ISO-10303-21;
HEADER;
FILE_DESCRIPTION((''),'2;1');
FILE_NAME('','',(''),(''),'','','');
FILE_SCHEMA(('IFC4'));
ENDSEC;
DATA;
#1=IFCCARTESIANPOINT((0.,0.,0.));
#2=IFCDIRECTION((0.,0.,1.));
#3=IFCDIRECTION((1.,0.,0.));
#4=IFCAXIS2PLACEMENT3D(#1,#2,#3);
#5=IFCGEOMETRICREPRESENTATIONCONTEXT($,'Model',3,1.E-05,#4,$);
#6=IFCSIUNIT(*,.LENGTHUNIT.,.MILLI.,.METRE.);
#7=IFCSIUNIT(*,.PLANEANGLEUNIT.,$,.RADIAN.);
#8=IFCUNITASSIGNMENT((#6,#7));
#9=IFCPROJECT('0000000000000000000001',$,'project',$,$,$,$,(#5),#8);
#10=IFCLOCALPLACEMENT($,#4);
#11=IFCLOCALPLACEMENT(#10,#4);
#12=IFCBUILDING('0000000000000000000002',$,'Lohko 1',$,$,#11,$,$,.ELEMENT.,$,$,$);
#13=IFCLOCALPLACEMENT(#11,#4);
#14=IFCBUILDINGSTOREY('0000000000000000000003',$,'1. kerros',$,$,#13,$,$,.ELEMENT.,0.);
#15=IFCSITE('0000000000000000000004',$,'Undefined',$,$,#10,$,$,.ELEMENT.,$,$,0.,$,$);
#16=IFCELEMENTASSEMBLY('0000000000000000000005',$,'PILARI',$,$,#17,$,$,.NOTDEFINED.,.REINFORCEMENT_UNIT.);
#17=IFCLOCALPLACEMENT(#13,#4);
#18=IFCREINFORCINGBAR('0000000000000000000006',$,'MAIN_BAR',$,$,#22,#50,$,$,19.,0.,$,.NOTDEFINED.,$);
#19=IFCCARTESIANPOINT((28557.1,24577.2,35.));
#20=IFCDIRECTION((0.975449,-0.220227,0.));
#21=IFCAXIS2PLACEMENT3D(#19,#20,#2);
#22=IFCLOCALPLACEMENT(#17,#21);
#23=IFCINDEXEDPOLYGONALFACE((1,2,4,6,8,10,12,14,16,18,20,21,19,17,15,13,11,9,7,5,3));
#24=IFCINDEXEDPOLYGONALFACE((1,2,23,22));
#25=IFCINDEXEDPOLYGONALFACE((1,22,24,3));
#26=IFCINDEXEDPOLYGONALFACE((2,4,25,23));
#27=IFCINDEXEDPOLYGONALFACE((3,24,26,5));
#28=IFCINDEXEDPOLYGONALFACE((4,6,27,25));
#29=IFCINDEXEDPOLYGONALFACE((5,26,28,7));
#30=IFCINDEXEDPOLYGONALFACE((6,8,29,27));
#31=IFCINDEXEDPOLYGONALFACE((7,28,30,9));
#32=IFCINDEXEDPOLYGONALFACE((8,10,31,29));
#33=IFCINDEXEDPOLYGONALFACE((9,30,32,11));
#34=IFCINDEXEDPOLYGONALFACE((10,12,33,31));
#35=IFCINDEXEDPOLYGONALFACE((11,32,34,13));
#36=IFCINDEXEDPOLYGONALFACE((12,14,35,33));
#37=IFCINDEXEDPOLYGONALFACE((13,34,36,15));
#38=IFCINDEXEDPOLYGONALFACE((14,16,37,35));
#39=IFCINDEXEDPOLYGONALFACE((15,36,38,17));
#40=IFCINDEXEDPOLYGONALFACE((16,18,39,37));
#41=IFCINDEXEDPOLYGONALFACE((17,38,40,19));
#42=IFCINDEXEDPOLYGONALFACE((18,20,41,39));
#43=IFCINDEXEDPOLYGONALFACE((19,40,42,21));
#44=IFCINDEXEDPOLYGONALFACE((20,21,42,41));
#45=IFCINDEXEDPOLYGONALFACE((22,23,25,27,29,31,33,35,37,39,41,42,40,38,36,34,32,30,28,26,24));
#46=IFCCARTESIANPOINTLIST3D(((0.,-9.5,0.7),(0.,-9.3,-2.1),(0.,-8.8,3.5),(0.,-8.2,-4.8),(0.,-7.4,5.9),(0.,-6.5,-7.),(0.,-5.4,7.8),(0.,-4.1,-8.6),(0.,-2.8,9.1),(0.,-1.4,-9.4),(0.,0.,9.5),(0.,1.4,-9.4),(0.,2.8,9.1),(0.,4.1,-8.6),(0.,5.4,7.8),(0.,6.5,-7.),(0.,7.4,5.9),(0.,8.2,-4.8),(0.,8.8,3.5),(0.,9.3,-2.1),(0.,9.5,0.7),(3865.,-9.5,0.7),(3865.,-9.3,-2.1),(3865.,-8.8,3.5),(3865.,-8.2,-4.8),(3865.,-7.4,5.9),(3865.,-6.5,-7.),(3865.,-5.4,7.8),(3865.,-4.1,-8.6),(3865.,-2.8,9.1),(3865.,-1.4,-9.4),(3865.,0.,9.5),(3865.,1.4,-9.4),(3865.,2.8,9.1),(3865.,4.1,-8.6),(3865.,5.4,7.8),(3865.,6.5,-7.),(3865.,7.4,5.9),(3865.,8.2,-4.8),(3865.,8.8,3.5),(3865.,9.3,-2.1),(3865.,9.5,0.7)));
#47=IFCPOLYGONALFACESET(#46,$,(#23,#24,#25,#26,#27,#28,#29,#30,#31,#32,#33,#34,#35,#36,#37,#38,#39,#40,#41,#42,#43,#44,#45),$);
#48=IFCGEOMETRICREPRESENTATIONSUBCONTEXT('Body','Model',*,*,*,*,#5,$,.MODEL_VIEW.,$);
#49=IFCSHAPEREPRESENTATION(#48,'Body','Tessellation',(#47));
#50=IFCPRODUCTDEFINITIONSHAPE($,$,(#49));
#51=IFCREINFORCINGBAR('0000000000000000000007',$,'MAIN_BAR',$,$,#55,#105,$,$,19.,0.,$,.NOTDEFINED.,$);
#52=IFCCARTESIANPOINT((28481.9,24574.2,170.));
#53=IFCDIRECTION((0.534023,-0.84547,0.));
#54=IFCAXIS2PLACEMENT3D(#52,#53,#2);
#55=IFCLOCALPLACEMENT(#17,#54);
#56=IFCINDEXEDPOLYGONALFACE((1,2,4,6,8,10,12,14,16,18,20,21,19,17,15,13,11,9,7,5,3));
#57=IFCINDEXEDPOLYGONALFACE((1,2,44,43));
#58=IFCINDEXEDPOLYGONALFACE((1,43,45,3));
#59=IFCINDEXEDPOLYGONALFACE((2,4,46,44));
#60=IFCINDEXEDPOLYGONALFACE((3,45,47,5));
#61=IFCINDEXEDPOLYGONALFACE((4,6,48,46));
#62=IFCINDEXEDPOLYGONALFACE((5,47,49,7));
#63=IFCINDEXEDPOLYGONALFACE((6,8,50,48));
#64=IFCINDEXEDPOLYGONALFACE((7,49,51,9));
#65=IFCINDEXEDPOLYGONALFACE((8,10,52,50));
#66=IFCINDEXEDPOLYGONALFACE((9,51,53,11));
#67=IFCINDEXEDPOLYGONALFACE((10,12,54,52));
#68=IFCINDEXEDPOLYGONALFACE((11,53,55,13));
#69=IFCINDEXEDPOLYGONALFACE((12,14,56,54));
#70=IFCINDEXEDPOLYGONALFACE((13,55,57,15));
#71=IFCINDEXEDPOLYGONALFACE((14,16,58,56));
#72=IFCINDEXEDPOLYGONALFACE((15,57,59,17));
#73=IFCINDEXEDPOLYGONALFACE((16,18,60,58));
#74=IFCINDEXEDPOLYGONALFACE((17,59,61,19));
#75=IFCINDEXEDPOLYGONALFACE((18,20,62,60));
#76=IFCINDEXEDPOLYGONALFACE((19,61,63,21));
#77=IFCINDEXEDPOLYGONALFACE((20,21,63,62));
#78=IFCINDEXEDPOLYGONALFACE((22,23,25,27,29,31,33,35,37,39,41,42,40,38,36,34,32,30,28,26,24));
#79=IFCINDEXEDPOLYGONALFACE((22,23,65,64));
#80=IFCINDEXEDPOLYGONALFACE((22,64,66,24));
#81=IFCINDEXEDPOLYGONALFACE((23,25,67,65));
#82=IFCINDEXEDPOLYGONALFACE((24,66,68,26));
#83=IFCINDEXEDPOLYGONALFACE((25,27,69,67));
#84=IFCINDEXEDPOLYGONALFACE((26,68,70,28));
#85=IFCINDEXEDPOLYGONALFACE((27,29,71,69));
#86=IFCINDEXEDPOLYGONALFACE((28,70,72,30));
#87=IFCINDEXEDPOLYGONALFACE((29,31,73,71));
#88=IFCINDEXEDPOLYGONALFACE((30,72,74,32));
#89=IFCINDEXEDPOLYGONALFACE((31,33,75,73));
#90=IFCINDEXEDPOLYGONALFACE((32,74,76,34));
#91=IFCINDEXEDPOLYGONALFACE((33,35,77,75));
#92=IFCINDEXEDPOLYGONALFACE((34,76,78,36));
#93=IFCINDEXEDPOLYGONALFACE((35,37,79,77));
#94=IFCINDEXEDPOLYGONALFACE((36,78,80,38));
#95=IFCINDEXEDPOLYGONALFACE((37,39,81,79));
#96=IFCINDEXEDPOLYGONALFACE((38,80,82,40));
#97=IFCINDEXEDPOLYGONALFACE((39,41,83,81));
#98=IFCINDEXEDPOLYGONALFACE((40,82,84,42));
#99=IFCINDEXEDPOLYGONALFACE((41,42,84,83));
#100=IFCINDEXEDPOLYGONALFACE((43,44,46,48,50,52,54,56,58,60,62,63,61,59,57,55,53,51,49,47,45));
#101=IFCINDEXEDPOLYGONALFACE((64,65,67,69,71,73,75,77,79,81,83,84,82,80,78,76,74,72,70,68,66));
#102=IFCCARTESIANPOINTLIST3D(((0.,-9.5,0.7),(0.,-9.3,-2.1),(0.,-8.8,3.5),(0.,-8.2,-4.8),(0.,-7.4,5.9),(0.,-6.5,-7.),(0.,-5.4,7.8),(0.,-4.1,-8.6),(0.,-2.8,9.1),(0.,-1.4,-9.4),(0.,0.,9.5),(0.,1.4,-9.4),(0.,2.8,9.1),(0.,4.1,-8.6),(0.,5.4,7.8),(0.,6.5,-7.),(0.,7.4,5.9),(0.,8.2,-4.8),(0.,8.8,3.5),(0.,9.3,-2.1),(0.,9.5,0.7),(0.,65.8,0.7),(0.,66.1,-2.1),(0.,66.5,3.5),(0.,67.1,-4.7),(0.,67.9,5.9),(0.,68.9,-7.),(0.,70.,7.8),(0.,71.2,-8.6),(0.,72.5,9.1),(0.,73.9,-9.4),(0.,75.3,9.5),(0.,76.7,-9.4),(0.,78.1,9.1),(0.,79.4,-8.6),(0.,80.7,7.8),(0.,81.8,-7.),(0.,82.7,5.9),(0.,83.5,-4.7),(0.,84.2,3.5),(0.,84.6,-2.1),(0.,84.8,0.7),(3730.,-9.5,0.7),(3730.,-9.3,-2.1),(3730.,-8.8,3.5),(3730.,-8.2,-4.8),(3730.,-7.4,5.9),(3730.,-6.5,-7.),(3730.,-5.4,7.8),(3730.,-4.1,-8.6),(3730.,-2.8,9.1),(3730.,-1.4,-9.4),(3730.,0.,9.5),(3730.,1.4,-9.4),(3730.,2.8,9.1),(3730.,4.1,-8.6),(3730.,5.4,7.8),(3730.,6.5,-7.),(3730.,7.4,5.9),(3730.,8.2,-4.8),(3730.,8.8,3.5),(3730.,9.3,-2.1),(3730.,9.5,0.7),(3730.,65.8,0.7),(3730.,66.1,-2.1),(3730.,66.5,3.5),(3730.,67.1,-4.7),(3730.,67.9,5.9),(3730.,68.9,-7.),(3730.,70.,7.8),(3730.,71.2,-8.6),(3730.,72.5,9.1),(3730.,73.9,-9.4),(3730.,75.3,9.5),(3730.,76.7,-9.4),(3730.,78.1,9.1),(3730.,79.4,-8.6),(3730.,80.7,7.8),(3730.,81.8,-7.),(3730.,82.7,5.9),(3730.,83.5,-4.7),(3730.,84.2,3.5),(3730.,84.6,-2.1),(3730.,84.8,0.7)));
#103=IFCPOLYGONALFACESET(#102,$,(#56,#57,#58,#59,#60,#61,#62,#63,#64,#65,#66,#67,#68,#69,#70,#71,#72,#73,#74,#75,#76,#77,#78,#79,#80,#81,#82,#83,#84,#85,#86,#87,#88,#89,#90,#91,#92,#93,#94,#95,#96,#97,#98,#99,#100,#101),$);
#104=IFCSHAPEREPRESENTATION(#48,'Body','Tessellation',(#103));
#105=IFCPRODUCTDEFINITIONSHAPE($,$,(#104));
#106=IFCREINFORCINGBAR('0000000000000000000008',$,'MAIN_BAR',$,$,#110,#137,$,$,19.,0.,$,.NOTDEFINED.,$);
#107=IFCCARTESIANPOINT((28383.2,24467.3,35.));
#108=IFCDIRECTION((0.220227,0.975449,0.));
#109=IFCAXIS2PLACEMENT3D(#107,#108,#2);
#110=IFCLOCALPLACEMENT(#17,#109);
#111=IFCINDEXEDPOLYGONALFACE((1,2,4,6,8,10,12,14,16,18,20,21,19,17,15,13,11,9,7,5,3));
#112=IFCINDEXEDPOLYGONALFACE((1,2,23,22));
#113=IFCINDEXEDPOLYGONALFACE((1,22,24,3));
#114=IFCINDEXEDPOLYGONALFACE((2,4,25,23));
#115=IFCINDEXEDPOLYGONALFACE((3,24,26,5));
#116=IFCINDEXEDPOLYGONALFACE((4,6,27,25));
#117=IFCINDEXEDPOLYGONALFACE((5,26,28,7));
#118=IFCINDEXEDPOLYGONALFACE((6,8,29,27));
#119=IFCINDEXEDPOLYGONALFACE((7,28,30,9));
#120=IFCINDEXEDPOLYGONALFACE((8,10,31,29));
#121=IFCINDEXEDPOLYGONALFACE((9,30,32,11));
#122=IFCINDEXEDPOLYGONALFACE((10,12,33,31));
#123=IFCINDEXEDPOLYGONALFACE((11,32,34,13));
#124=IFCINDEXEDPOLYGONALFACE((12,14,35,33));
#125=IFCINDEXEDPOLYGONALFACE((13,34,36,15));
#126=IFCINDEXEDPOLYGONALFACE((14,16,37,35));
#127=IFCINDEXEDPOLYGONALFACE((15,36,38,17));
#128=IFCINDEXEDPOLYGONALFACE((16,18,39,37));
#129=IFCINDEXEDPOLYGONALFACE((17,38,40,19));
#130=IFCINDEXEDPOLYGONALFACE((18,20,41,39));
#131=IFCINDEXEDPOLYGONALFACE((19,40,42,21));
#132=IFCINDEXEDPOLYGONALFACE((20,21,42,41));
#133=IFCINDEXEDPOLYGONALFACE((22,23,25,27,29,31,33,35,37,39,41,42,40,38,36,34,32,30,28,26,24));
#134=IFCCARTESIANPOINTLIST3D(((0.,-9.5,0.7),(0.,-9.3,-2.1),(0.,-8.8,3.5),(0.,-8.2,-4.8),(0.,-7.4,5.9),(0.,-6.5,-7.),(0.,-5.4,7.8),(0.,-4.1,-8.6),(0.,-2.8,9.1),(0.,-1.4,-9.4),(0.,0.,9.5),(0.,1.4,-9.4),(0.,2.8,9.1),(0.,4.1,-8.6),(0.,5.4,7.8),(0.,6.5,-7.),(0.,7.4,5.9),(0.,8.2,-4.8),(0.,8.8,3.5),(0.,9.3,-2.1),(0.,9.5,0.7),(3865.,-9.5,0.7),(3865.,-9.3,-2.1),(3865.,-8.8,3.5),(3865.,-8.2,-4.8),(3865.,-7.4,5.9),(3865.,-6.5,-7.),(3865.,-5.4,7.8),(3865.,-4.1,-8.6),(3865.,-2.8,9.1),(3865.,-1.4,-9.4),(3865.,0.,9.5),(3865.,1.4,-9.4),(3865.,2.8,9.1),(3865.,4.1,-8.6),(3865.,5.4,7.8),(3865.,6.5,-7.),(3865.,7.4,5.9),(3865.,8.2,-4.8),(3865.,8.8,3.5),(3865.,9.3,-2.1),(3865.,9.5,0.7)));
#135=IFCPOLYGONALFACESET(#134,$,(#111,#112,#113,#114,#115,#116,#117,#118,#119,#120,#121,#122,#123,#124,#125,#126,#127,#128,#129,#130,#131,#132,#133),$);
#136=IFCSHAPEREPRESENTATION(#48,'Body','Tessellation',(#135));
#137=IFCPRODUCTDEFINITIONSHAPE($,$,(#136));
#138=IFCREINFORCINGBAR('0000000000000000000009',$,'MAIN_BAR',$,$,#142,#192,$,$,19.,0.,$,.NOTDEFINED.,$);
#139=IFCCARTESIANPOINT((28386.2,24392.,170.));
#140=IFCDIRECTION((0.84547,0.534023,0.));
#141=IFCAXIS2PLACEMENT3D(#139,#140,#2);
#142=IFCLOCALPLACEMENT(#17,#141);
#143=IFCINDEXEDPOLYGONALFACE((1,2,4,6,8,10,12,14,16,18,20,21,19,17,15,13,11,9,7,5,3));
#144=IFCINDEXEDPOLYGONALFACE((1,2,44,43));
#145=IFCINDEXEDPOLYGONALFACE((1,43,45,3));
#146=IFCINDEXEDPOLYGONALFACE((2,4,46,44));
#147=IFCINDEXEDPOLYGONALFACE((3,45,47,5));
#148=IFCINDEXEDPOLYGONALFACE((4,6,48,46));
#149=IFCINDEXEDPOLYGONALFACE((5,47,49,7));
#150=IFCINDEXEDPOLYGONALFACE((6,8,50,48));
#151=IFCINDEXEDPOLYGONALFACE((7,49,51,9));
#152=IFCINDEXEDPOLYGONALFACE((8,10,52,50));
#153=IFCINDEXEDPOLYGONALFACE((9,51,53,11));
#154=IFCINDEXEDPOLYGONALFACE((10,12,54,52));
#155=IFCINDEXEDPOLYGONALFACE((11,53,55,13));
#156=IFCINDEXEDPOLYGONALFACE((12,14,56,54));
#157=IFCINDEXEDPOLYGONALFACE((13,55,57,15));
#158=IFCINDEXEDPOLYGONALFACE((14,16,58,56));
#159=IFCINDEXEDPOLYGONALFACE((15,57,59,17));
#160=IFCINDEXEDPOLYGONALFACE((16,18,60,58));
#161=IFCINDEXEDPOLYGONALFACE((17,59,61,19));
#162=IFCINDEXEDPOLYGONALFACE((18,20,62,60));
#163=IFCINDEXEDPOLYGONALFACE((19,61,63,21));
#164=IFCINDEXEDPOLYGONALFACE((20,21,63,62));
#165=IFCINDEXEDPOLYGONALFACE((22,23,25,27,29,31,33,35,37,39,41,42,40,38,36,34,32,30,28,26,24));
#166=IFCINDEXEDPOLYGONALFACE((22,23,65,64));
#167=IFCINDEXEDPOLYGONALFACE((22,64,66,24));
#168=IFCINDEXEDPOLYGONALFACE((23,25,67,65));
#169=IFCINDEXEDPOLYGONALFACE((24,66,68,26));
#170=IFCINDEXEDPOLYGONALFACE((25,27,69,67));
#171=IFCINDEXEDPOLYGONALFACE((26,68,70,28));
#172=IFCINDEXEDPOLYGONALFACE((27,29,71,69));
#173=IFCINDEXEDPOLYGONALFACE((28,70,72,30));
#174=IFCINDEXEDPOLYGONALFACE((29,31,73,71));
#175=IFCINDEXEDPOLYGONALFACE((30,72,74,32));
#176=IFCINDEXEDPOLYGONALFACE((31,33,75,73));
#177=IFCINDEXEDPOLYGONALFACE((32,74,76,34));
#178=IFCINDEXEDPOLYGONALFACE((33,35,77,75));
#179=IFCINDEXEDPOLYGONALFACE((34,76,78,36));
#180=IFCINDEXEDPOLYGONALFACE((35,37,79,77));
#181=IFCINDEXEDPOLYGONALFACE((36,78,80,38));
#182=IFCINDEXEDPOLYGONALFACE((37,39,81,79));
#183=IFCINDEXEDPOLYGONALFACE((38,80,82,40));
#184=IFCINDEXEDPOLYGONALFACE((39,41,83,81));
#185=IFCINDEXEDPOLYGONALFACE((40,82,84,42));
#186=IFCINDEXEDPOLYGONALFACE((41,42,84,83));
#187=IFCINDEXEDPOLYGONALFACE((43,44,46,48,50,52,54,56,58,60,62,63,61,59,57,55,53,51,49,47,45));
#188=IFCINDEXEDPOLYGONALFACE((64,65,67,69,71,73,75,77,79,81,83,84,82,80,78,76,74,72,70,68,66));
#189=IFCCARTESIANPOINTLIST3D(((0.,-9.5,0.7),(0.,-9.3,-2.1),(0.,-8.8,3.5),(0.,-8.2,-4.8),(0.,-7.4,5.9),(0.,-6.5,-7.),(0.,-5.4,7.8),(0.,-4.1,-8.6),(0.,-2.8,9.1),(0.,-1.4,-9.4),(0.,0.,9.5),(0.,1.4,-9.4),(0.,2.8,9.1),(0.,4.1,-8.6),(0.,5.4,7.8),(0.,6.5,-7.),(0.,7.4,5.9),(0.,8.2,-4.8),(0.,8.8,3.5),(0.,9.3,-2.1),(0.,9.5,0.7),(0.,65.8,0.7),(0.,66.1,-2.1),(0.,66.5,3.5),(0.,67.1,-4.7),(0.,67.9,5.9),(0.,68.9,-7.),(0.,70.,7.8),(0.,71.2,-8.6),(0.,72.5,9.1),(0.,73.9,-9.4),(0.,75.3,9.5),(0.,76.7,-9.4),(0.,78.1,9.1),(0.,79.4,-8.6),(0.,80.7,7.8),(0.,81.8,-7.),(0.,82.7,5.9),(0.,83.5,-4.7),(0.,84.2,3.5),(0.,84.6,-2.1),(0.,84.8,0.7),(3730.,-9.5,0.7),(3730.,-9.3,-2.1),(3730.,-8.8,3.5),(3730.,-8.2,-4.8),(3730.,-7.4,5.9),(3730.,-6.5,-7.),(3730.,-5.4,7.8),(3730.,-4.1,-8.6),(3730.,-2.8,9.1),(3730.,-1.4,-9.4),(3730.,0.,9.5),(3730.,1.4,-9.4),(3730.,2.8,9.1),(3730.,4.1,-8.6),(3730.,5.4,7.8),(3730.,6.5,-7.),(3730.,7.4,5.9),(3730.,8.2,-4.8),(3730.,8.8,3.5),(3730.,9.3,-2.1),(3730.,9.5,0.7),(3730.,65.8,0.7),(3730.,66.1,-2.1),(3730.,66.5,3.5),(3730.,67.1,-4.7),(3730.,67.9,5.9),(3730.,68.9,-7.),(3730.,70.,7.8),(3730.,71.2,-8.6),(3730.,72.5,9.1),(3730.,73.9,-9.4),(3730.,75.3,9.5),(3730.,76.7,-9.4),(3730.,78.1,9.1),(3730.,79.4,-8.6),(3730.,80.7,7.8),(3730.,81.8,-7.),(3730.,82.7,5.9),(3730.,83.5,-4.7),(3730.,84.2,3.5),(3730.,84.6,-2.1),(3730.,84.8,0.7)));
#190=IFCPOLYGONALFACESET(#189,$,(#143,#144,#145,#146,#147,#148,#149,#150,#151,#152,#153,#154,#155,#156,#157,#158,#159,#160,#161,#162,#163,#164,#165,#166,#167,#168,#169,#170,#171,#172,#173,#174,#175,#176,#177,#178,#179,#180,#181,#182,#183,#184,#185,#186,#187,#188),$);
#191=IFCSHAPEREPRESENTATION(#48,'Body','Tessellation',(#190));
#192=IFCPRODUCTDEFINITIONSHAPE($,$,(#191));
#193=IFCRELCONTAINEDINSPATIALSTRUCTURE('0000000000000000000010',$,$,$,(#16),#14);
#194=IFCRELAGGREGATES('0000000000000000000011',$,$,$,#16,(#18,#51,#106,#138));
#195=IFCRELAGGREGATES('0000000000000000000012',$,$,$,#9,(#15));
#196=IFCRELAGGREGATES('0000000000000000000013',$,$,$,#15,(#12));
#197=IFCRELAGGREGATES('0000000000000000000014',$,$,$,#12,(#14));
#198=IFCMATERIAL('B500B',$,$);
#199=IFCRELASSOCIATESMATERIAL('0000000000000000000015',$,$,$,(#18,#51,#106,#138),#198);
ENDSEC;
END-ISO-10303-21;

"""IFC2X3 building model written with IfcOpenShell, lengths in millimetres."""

from ifc_helpers import new_model, entity, si_unit, frame, origin_with_axes, place, context, subcontext, project, spatial, source, transform, mapped, material, element, aggregate, save


model = new_model("IFC2X3")

# Units and contexts
model_context = context("Model", 3, precision=1e-05, world=origin_with_axes())
body_context = subcontext(model_context, "Body", "Model", "MODEL_VIEW")
ifc_project = project(units=[si_unit("LENGTHUNIT", "METRE", prefix="MILLI"), si_unit("PLANEANGLEUNIT", "RADIAN")], contexts=[model_context])

# Site, building, storey
site_placement = place(None, origin_with_axes())
site = spatial("IfcSite", under=ifc_project, at=site_placement, Name="Undefined", CompositionType="ELEMENT", RefElevation=0.0)
building_placement = place(site_placement, origin_with_axes())
building = spatial("IfcBuilding", under=site, at=building_placement, Name="Lohko 1", CompositionType="ELEMENT")
storey_placement = place(building_placement, origin_with_axes())
storey = spatial("IfcBuildingStorey", under=building, at=storey_placement, Name="1. kerros", CompositionType="ELEMENT", Elevation=0.0)

# Element assembly, reinforcing bars
assembly_placement = place(storey_placement, origin_with_axes())
assembly = element("IfcElementAssembly", 1, at=assembly_placement, inside=storey, Name="PILARI", AssemblyPlace="NOTDEFINED", PredefinedType="REINFORCEMENT_UNIT")
ifc_material = material(Name="B500B")
shared_shape_1 = source(origin_with_axes(), body_context, "Body", "AdvancedSweptSolid", [
    entity("IfcSweptDiskSolid", entity("IfcTrimmedCurve", entity("IfcLine", entity("IfcCartesianPoint", [0.0, 0.0, 0.0]), entity("IfcVector", entity("IfcDirection", [1.0, 0.0, 0.0]), 1.0)), [entity("IfcParameterValue", 0.0)], [entity("IfcParameterValue", 3865.0)], True, "PARAMETER"), 9.5, None, 0.0, 3865.0),
])
reinforcing_bar_1_placement = place(assembly_placement, frame((28557.1, 24577.2, 35.0), z_axis=(0.975449, -0.220227, 0.0), x_axis=(0.0, 0.0, 1.0)))
reinforcing_bar_1 = element("IfcReinforcingBar", 2, at=reinforcing_bar_1_placement, material=ifc_material, Name="MAIN_BAR", BarRole="NOTDEFINED", CrossSectionArea=0.0, NominalDiameter=19.0, context=body_context, shape_type="MappedRepresentation", body=[
    mapped(shared_shape_1, transform((0.0, 0.0, 0.0))),
])
shared_shape_2 = source(origin_with_axes(), body_context, "Body", "AdvancedSweptSolid", [
    entity("IfcSweptDiskSolid", entity("IfcTrimmedCurve", entity("IfcLine", entity("IfcCartesianPoint", [0.0, 0.0, 0.0]), entity("IfcVector", entity("IfcDirection", [1.0, 0.0, 0.0]), 1.0)), [entity("IfcParameterValue", 0.0)], [entity("IfcParameterValue", 3730.0)], True, "PARAMETER"), 9.5, None, 0.0, 3730.0),
])
shared_shape_3 = source(origin_with_axes(), body_context, "Body", "AdvancedSweptSolid", [
    entity("IfcSweptDiskSolid", entity("IfcTrimmedCurve", entity("IfcLine", entity("IfcCartesianPoint", [0.0, 0.0, 0.0]), entity("IfcVector", entity("IfcDirection", [1.0, 0.0, 0.0]), 1.0)), [entity("IfcParameterValue", 0.0)], [entity("IfcParameterValue", 3730.0)], True, "PARAMETER"), 9.5, None, 0.0, 3730.0),
])
reinforcing_bar_2_placement = place(assembly_placement, frame((28481.9, 24574.2, 170.0), z_axis=(0.534023, -0.84547, 0.0), x_axis=(0.0, 0.0, 1.0)))
reinforcing_bar_2 = element("IfcReinforcingBar", 3, at=reinforcing_bar_2_placement, material=ifc_material, Name="MAIN_BAR", BarRole="NOTDEFINED", CrossSectionArea=0.0, NominalDiameter=19.0, context=body_context, shape_type="MappedRepresentation", body=[
    mapped(shared_shape_2, transform((0.0, 0.0, 0.0))),
    mapped(shared_shape_3, transform((0.0, 75.3, 0.0))),
])
shared_shape_4 = source(origin_with_axes(), body_context, "Body", "AdvancedSweptSolid", [
    entity("IfcSweptDiskSolid", entity("IfcTrimmedCurve", entity("IfcLine", entity("IfcCartesianPoint", [0.0, 0.0, 0.0]), entity("IfcVector", entity("IfcDirection", [1.0, 0.0, 0.0]), 1.0)), [entity("IfcParameterValue", 0.0)], [entity("IfcParameterValue", 3865.0)], True, "PARAMETER"), 9.5, None, 0.0, 3865.0),
])
reinforcing_bar_3_placement = place(assembly_placement, frame((28383.2, 24467.3, 35.0), z_axis=(0.220227, 0.975449, 0.0), x_axis=(0.0, 0.0, 1.0)))
reinforcing_bar_3 = element("IfcReinforcingBar", 4, at=reinforcing_bar_3_placement, material=ifc_material, Name="MAIN_BAR", BarRole="NOTDEFINED", CrossSectionArea=0.0, NominalDiameter=19.0, context=body_context, shape_type="MappedRepresentation", body=[
    mapped(shared_shape_4, transform((0.0, 0.0, 0.0))),
])
shared_shape_5 = source(origin_with_axes(), body_context, "Body", "AdvancedSweptSolid", [
    entity("IfcSweptDiskSolid", entity("IfcTrimmedCurve", entity("IfcLine", entity("IfcCartesianPoint", [0.0, 0.0, 0.0]), entity("IfcVector", entity("IfcDirection", [1.0, 0.0, 0.0]), 1.0)), [entity("IfcParameterValue", 0.0)], [entity("IfcParameterValue", 3730.0)], True, "PARAMETER"), 9.5, None, 0.0, 3730.0),
])
shared_shape_6 = source(origin_with_axes(), body_context, "Body", "AdvancedSweptSolid", [
    entity("IfcSweptDiskSolid", entity("IfcTrimmedCurve", entity("IfcLine", entity("IfcCartesianPoint", [0.0, 0.0, 0.0]), entity("IfcVector", entity("IfcDirection", [1.0, 0.0, 0.0]), 1.0)), [entity("IfcParameterValue", 0.0)], [entity("IfcParameterValue", 3730.0)], True, "PARAMETER"), 9.5, None, 0.0, 3730.0),
])
reinforcing_bar_4_placement = place(assembly_placement, frame((28386.2, 24392.0, 170.0), z_axis=(0.84547, 0.534023, 0.0), x_axis=(0.0, 0.0, 1.0)))
reinforcing_bar_4 = element("IfcReinforcingBar", 5, at=reinforcing_bar_4_placement, material=ifc_material, Name="MAIN_BAR", BarRole="NOTDEFINED", CrossSectionArea=0.0, NominalDiameter=19.0, context=body_context, shape_type="MappedRepresentation", body=[
    mapped(shared_shape_5, transform((0.0, 0.0, 0.0))),
    mapped(shared_shape_6, transform((0.0, 75.3, 0.0))),
])
aggregate(assembly, [reinforcing_bar_1, reinforcing_bar_2, reinforcing_bar_3, reinforcing_bar_4])

save(model, "model.ifc")
